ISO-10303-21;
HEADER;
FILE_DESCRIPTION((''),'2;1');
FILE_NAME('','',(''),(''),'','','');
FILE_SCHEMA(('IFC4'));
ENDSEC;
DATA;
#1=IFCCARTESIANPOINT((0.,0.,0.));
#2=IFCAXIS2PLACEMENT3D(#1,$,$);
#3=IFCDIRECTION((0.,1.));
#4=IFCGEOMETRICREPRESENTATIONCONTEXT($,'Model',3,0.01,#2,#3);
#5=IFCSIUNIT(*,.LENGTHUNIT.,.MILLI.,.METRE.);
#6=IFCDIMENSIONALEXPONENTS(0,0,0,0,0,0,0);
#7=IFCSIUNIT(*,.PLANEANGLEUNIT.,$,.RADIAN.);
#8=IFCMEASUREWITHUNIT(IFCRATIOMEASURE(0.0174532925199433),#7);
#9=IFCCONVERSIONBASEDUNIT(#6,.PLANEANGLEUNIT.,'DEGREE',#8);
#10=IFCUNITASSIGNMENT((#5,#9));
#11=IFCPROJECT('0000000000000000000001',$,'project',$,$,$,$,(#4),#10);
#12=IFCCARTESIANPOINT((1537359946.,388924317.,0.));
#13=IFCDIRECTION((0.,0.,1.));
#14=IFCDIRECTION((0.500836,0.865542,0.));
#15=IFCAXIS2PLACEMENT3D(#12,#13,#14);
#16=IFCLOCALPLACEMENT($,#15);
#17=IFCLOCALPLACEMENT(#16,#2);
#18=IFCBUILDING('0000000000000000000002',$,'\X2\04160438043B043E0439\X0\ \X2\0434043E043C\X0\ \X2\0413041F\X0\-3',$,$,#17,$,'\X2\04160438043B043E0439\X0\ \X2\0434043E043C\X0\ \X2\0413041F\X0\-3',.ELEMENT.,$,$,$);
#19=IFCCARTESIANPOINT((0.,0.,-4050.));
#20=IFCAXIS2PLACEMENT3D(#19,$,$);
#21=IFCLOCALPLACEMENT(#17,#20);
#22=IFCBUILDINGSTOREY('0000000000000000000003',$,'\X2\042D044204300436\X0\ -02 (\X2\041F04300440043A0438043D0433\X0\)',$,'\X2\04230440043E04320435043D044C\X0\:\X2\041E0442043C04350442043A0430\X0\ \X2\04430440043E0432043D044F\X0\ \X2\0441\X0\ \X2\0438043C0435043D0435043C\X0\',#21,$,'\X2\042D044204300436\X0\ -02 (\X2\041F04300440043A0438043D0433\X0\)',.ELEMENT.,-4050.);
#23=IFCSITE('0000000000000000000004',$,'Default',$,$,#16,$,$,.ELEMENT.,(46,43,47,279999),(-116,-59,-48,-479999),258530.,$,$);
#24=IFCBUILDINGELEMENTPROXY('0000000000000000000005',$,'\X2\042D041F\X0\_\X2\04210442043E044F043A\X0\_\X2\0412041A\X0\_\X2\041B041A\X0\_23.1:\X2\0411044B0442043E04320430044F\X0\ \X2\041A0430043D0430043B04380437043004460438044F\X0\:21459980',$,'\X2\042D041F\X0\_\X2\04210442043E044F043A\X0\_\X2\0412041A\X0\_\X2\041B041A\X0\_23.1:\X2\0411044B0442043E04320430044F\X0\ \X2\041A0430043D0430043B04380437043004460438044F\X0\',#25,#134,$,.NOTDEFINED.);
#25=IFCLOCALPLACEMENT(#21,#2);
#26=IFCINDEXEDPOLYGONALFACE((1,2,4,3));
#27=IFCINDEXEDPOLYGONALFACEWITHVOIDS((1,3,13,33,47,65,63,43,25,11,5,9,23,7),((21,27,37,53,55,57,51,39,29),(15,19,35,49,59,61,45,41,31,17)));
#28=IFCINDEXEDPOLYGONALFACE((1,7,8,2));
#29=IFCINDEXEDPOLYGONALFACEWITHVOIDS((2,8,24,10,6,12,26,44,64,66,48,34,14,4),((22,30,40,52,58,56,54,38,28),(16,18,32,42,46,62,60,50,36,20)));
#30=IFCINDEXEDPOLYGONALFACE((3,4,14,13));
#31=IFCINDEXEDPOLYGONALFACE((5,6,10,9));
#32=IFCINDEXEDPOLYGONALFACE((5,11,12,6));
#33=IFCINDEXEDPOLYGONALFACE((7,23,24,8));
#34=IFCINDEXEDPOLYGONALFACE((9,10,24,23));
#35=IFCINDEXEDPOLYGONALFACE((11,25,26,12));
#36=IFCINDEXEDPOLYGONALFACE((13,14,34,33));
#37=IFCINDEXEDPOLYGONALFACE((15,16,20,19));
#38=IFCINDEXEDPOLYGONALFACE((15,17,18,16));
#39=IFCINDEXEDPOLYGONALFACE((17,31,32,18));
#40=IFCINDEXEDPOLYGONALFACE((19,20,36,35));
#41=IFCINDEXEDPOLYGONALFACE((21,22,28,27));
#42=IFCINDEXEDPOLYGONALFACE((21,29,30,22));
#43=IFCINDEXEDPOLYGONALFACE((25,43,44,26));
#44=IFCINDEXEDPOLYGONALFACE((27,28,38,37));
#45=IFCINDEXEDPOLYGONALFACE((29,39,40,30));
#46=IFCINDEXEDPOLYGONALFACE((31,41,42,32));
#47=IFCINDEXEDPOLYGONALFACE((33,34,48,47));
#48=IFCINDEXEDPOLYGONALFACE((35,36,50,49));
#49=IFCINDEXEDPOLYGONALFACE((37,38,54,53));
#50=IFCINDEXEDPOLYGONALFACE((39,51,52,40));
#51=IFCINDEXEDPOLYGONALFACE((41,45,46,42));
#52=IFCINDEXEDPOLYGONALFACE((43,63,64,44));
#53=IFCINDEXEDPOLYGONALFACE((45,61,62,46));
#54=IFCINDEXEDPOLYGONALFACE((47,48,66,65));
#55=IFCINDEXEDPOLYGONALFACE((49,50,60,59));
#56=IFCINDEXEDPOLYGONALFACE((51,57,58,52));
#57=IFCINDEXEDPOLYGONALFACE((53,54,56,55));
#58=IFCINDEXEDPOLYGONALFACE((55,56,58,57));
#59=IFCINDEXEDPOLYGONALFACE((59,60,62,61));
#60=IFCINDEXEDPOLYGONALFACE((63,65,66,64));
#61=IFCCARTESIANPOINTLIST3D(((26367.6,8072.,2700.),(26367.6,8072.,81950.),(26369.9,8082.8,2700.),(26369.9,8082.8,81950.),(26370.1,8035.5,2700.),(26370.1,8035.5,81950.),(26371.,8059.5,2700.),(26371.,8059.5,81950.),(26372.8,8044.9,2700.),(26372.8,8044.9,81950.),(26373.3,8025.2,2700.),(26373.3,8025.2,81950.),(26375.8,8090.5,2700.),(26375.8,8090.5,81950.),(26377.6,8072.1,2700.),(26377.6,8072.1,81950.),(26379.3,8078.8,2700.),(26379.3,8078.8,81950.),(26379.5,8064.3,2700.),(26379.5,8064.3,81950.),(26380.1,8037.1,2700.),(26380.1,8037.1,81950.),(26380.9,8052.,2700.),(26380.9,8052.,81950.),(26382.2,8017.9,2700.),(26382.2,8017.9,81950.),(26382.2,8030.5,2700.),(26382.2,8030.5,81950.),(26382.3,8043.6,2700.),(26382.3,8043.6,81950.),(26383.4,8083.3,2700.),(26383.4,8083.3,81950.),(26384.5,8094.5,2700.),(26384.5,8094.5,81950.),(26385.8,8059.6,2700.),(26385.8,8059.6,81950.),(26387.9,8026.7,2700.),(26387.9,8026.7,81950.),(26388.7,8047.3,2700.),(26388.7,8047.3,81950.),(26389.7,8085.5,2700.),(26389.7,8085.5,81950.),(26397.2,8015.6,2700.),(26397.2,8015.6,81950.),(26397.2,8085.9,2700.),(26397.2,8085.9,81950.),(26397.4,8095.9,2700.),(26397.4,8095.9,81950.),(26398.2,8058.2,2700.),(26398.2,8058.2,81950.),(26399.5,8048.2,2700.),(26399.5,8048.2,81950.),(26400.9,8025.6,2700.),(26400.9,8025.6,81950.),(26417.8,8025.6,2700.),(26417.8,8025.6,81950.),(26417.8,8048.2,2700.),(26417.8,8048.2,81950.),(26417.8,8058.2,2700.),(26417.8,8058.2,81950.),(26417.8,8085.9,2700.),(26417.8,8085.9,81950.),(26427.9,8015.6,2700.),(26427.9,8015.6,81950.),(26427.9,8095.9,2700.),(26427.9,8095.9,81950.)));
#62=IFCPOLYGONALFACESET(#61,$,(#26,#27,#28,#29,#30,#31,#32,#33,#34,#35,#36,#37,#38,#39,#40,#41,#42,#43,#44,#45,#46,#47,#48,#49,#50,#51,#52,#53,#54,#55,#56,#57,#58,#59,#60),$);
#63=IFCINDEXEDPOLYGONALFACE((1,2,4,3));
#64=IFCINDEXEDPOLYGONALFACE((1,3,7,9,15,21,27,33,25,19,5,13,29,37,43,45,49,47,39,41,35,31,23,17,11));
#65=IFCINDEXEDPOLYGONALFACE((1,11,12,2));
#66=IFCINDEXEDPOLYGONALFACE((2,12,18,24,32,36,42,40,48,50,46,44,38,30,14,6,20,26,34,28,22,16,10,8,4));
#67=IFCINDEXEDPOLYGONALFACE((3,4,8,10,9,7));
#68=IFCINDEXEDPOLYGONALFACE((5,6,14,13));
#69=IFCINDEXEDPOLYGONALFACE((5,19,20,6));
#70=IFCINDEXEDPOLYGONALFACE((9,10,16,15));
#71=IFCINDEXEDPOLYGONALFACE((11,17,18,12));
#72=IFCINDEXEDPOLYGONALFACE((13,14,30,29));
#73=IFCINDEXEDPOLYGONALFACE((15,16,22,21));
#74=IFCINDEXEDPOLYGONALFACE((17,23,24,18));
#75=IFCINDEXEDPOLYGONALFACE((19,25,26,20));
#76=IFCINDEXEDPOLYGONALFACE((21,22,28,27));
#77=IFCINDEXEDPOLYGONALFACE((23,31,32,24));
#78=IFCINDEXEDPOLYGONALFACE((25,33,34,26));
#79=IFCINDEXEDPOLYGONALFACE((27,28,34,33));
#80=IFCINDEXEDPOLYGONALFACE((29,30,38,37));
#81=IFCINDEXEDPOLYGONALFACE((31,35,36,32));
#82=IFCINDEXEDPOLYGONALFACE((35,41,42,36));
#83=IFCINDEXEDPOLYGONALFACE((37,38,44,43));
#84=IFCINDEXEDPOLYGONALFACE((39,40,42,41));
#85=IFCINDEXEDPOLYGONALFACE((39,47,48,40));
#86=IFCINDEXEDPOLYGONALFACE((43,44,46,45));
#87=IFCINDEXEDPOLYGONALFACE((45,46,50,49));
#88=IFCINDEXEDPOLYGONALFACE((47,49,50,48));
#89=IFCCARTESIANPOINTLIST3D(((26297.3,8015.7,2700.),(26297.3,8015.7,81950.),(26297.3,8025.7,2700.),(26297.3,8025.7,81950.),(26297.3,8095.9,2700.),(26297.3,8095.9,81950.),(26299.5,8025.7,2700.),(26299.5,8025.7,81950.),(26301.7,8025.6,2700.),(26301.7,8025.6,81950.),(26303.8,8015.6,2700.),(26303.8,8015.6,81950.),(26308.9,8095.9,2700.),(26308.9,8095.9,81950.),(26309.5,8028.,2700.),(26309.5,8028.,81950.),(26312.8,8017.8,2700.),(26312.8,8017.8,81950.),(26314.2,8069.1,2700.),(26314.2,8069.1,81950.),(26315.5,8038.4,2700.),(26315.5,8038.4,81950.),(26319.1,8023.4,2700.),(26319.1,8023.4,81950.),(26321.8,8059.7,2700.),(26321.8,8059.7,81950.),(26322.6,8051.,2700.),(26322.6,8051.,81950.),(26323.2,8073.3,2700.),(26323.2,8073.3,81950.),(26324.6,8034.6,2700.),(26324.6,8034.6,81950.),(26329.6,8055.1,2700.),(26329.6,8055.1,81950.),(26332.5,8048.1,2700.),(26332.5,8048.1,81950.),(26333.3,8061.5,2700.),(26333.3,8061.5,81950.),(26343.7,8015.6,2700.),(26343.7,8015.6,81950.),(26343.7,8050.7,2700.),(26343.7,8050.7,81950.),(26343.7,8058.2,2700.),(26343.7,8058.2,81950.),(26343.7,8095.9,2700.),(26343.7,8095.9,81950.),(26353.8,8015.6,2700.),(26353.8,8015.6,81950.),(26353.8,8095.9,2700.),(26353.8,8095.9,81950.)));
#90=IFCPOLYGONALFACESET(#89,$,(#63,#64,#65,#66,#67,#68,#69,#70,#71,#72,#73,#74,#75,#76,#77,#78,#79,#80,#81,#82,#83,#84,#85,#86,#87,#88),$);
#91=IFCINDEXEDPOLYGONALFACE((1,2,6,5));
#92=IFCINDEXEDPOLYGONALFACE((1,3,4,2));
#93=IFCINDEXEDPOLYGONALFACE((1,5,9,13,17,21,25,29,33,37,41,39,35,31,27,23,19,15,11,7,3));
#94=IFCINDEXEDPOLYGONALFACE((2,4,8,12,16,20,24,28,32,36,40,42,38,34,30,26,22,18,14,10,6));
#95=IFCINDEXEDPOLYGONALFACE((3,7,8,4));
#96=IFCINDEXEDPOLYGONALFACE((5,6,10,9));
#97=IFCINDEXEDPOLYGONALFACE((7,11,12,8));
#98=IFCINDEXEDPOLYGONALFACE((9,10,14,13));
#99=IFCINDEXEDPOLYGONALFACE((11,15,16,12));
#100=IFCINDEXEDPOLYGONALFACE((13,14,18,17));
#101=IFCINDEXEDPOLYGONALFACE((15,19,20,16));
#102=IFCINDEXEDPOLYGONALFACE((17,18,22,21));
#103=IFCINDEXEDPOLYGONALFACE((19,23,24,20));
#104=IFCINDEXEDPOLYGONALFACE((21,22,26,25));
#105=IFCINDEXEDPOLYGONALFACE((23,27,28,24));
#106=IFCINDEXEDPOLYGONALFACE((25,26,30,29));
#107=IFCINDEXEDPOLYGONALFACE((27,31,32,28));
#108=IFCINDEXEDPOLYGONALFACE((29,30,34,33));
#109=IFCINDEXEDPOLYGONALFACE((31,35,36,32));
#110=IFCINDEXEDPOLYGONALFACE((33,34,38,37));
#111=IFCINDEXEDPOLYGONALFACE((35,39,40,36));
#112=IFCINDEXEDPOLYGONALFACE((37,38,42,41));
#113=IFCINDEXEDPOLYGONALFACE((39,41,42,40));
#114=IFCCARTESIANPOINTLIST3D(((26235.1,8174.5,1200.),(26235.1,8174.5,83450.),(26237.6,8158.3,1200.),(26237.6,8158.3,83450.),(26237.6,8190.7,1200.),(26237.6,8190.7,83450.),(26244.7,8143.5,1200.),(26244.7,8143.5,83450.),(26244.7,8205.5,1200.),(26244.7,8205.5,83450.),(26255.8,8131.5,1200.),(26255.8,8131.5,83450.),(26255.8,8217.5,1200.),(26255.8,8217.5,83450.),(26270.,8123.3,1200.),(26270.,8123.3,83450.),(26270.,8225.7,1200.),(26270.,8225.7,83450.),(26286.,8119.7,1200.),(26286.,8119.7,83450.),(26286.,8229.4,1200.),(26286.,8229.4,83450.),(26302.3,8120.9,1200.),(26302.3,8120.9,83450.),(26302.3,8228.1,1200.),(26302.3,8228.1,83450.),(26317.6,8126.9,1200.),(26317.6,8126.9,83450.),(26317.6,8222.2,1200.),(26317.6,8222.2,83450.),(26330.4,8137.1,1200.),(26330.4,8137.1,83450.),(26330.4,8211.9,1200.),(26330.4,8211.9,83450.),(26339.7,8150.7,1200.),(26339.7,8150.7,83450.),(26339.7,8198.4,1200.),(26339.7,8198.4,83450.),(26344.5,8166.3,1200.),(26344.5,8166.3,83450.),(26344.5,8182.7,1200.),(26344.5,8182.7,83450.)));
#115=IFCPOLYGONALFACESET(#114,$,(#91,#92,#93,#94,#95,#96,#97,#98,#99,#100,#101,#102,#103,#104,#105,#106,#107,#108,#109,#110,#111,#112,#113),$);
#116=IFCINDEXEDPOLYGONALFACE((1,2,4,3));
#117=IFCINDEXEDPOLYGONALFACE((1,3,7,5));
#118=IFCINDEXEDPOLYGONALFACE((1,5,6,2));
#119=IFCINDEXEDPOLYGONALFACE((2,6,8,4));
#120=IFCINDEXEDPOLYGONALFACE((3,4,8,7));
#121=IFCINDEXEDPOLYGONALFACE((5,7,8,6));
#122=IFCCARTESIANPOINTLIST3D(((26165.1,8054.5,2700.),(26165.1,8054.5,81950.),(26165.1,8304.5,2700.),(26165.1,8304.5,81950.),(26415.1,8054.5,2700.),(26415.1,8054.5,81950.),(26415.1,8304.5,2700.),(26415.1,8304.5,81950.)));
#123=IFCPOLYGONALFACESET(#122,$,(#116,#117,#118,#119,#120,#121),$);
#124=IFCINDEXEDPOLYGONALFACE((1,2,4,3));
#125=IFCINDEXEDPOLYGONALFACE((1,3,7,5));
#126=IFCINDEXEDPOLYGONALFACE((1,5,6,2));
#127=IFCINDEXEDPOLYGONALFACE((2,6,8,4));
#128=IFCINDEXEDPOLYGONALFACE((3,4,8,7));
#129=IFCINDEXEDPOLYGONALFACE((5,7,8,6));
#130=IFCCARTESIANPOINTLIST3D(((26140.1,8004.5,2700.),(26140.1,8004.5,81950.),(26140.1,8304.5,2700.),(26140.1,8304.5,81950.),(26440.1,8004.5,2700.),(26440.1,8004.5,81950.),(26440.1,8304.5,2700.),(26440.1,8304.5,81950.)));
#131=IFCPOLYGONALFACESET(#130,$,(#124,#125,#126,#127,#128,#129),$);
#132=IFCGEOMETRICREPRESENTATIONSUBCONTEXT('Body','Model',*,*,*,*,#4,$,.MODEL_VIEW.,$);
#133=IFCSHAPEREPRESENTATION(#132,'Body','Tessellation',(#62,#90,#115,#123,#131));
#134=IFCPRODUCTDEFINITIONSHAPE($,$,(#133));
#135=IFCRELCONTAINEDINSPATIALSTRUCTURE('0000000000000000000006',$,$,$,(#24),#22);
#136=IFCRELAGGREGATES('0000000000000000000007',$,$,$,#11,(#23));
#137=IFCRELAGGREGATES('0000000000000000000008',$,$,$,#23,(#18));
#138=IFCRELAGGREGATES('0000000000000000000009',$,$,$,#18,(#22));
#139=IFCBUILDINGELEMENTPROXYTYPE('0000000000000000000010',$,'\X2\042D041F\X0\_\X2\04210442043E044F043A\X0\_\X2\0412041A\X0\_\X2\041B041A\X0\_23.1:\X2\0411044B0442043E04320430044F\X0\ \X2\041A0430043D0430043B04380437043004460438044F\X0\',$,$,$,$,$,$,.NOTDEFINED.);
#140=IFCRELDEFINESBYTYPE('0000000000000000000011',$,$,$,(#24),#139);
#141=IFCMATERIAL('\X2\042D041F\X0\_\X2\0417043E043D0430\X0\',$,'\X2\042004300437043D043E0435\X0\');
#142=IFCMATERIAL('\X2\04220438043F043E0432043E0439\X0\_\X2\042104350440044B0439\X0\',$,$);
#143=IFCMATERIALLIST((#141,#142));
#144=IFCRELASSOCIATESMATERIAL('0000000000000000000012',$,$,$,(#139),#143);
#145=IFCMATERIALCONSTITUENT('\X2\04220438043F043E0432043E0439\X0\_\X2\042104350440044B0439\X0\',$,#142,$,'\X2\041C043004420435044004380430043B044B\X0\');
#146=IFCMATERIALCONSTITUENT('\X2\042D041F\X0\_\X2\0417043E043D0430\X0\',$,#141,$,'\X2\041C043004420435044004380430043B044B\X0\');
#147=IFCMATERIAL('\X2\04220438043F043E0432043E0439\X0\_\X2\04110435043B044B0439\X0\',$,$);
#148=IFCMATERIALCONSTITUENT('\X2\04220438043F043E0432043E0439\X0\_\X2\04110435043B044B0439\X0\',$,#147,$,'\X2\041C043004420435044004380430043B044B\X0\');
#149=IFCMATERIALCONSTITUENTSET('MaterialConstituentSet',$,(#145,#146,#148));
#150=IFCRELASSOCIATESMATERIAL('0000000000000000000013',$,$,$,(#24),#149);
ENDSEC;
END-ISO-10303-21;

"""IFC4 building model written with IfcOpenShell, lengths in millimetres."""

from ifc_helpers import new_model, entity, si_unit, converted_unit, direction, frame, frame_2d, origin, place, context, subcontext, project, spatial, polyline, rectangle, circle, outline, extrude, source, transform, mapped, material, material_list, constituent, constituent_set, type_object, type_shapes, element, save


model = new_model("IFC4")

# Units and contexts
model_context = context("Model", 3, precision=0.01, world=origin(), true_north=direction((0.0, 1.0)))
body_context = subcontext(model_context, "Body", "Model", "MODEL_VIEW")
ifc_project = project(units=[si_unit("LENGTHUNIT", "METRE", prefix="MILLI"), converted_unit("PLANEANGLEUNIT", "DEGREE", entity("IfcRatioMeasure", 0.0174532925199433), si_unit("PLANEANGLEUNIT", "RADIAN"), dimensions=[0, 0, 0, 0, 0, 0, 0])], contexts=[model_context])

# Site, building, storey
site_placement = place(None, frame((1537359946.0, 388924317.0, 0.0), z_axis=(0.0, 0.0, 1.0), x_axis=(0.500836, 0.865542, 0.0)))
site = spatial("IfcSite", under=ifc_project, at=site_placement, Name="Default", CompositionType="ELEMENT", RefLatitude=(46, 43, 47, 279999), RefLongitude=(-116, -59, -48, -479999), RefElevation=258530.0)
building_placement = place(site_placement, origin())
building = spatial("IfcBuilding", under=site, at=building_placement, Name="Жилой дом ГП-3", LongName="Жилой дом ГП-3", CompositionType="ELEMENT")
storey_placement = place(building_placement, frame((0.0, 0.0, -4050.0)))
storey = spatial("IfcBuildingStorey", under=building, at=storey_placement, Name="Этаж -02 (Паркинг)", ObjectType="Уровень:Отметка уровня с именем", LongName="Этаж -02 (Паркинг)", CompositionType="ELEMENT", Elevation=-4050.0)

# Building element proxy
ifc_material_1 = material(Name="ЭП_Зона", Category="Разное")
ifc_material_2 = material(Name="Типовой_Белый")
ifc_material_3 = material(Name="Типовой_Серый")
ifc_material_list_1 = material_list([ifc_material_1, ifc_material_3])
building_element_proxy_type_1 = type_object("IfcBuildingElementProxyType", Name="ЭП_Стояк_ВК_ЛК_23.1:Бытовая Канализация", PredefinedType="NOTDEFINED", material=ifc_material_list_1)
shared_shape_1 = source(origin(), body_context, "Body", "SweptSolid", [
    extrude(outline(polyline([(-42.2, -39.0), (-11.8, -39.0), (1.1, -37.6), (9.8, -33.5), (15.7, -25.8), (18.0, -15.0), (14.6, -2.5), (4.7, 5.0), (12.8, 12.1), (15.5, 21.5), (12.3, 31.8), (3.4, 39.0), (-11.6, 41.4), (-42.2, 41.4), (-42.2, -39.0)]), holes=[polyline([(-32.2, 8.8), (-32.2, 31.4), (-15.2, 31.4), (-2.3, 30.3), (3.5, 26.4), (5.5, 19.9), (3.3, 13.3), (-3.1, 9.6), (-13.9, 8.8), (-32.2, 8.8)]), polyline([(-32.2, -28.9), (-32.2, -1.3), (-12.6, -1.3), (-0.2, -2.6), (6.1, -7.3), (8.0, -15.1), (6.3, -21.9), (2.2, -26.3), (-4.1, -28.5), (-11.6, -28.9), (-32.2, -28.9)])]), frame((54.5, -52.4, -1350.0)), (0.0, 0.0, 1.0), 79250.0),
    extrude(outline(polyline([(-32.1, -31.9), (48.3, -31.9), (48.3, -21.8), (10.6, -21.8), (13.8, -11.4), (25.6, -1.3), (48.3, 13.0), (48.3, 24.6), (21.4, 7.7), (12.0, 0.1), (7.4, -7.7), (3.3, -0.7), (-9.3, 6.4), (-19.7, 12.3), (-22.1, 20.2), (-22.0, 22.4), (-22.0, 24.6), (-32.0, 24.6), (-32.1, 18.0), (-29.9, 9.0), (-24.3, 2.8), (-13.1, -2.8), (0.4, -10.6), (3.0, -21.8), (-32.1, -21.8), (-32.1, -31.9)])), frame((118.2, -43.1, -1350.0), z_axis=(0.0, 0.0, 1.0), x_axis=(0.0, -1.0, 0.0)), (0.0, 0.0, 1.0), 79250.0),
    extrude(circle(Radius=55.0, at=frame_2d((0.0, 0.0), x_axis=(1.0, 0.0))), frame((150.0, -170.0, -2850.0)), (0.0, 0.0, 1.0), 82250.0),
    extrude(rectangle(XDim=250.0, YDim=250.0, at=frame_2d((0.0, 0.0), x_axis=(1.0, 0.0))), frame((150.0, -175.0, -1350.0)), (0.0, 0.0, 1.0), 79250.0),
    extrude(rectangle(XDim=300.0, YDim=300.0, at=frame_2d((0.0, 0.0), x_axis=(1.0, 0.0))), frame((150.0, -150.0, -1350.0)), (0.0, 0.0, 1.0), 79250.0),
])
type_shapes(building_element_proxy_type_1, [shared_shape_1])
ifc_constituent_1 = constituent(ifc_material_3, Name="Типовой_Серый", Category="Материалы")
ifc_constituent_2 = constituent(ifc_material_1, Name="ЭП_Зона", Category="Материалы")
ifc_constituent_3 = constituent(ifc_material_2, Name="Типовой_Белый", Category="Материалы")
ifc_constituent_set_1 = constituent_set(constituents=[ifc_constituent_1, ifc_constituent_2, ifc_constituent_3], Name="MaterialConstituentSet")
proxy_1_placement = place(storey_placement, frame((26440.1, 8004.5, 4050.0), z_axis=(0.0, 0.0, 1.0), x_axis=(-1.0, 0.0, 0.0)))
element("IfcBuildingElementProxy", 1, at=proxy_1_placement, inside=storey, type_object=building_element_proxy_type_1, material=ifc_constituent_set_1, Name="ЭП_Стояк_ВК_ЛК_23.1:Бытовая Канализация:21459980", ObjectType="ЭП_Стояк_ВК_ЛК_23.1:Бытовая Канализация", PredefinedType="NOTDEFINED", context=body_context, shape_type="MappedRepresentation", body=[
    mapped(shared_shape_1, transform((0.0, 0.0, 0.0), scale=1.0)),
])

save(model, "model.ifc")
